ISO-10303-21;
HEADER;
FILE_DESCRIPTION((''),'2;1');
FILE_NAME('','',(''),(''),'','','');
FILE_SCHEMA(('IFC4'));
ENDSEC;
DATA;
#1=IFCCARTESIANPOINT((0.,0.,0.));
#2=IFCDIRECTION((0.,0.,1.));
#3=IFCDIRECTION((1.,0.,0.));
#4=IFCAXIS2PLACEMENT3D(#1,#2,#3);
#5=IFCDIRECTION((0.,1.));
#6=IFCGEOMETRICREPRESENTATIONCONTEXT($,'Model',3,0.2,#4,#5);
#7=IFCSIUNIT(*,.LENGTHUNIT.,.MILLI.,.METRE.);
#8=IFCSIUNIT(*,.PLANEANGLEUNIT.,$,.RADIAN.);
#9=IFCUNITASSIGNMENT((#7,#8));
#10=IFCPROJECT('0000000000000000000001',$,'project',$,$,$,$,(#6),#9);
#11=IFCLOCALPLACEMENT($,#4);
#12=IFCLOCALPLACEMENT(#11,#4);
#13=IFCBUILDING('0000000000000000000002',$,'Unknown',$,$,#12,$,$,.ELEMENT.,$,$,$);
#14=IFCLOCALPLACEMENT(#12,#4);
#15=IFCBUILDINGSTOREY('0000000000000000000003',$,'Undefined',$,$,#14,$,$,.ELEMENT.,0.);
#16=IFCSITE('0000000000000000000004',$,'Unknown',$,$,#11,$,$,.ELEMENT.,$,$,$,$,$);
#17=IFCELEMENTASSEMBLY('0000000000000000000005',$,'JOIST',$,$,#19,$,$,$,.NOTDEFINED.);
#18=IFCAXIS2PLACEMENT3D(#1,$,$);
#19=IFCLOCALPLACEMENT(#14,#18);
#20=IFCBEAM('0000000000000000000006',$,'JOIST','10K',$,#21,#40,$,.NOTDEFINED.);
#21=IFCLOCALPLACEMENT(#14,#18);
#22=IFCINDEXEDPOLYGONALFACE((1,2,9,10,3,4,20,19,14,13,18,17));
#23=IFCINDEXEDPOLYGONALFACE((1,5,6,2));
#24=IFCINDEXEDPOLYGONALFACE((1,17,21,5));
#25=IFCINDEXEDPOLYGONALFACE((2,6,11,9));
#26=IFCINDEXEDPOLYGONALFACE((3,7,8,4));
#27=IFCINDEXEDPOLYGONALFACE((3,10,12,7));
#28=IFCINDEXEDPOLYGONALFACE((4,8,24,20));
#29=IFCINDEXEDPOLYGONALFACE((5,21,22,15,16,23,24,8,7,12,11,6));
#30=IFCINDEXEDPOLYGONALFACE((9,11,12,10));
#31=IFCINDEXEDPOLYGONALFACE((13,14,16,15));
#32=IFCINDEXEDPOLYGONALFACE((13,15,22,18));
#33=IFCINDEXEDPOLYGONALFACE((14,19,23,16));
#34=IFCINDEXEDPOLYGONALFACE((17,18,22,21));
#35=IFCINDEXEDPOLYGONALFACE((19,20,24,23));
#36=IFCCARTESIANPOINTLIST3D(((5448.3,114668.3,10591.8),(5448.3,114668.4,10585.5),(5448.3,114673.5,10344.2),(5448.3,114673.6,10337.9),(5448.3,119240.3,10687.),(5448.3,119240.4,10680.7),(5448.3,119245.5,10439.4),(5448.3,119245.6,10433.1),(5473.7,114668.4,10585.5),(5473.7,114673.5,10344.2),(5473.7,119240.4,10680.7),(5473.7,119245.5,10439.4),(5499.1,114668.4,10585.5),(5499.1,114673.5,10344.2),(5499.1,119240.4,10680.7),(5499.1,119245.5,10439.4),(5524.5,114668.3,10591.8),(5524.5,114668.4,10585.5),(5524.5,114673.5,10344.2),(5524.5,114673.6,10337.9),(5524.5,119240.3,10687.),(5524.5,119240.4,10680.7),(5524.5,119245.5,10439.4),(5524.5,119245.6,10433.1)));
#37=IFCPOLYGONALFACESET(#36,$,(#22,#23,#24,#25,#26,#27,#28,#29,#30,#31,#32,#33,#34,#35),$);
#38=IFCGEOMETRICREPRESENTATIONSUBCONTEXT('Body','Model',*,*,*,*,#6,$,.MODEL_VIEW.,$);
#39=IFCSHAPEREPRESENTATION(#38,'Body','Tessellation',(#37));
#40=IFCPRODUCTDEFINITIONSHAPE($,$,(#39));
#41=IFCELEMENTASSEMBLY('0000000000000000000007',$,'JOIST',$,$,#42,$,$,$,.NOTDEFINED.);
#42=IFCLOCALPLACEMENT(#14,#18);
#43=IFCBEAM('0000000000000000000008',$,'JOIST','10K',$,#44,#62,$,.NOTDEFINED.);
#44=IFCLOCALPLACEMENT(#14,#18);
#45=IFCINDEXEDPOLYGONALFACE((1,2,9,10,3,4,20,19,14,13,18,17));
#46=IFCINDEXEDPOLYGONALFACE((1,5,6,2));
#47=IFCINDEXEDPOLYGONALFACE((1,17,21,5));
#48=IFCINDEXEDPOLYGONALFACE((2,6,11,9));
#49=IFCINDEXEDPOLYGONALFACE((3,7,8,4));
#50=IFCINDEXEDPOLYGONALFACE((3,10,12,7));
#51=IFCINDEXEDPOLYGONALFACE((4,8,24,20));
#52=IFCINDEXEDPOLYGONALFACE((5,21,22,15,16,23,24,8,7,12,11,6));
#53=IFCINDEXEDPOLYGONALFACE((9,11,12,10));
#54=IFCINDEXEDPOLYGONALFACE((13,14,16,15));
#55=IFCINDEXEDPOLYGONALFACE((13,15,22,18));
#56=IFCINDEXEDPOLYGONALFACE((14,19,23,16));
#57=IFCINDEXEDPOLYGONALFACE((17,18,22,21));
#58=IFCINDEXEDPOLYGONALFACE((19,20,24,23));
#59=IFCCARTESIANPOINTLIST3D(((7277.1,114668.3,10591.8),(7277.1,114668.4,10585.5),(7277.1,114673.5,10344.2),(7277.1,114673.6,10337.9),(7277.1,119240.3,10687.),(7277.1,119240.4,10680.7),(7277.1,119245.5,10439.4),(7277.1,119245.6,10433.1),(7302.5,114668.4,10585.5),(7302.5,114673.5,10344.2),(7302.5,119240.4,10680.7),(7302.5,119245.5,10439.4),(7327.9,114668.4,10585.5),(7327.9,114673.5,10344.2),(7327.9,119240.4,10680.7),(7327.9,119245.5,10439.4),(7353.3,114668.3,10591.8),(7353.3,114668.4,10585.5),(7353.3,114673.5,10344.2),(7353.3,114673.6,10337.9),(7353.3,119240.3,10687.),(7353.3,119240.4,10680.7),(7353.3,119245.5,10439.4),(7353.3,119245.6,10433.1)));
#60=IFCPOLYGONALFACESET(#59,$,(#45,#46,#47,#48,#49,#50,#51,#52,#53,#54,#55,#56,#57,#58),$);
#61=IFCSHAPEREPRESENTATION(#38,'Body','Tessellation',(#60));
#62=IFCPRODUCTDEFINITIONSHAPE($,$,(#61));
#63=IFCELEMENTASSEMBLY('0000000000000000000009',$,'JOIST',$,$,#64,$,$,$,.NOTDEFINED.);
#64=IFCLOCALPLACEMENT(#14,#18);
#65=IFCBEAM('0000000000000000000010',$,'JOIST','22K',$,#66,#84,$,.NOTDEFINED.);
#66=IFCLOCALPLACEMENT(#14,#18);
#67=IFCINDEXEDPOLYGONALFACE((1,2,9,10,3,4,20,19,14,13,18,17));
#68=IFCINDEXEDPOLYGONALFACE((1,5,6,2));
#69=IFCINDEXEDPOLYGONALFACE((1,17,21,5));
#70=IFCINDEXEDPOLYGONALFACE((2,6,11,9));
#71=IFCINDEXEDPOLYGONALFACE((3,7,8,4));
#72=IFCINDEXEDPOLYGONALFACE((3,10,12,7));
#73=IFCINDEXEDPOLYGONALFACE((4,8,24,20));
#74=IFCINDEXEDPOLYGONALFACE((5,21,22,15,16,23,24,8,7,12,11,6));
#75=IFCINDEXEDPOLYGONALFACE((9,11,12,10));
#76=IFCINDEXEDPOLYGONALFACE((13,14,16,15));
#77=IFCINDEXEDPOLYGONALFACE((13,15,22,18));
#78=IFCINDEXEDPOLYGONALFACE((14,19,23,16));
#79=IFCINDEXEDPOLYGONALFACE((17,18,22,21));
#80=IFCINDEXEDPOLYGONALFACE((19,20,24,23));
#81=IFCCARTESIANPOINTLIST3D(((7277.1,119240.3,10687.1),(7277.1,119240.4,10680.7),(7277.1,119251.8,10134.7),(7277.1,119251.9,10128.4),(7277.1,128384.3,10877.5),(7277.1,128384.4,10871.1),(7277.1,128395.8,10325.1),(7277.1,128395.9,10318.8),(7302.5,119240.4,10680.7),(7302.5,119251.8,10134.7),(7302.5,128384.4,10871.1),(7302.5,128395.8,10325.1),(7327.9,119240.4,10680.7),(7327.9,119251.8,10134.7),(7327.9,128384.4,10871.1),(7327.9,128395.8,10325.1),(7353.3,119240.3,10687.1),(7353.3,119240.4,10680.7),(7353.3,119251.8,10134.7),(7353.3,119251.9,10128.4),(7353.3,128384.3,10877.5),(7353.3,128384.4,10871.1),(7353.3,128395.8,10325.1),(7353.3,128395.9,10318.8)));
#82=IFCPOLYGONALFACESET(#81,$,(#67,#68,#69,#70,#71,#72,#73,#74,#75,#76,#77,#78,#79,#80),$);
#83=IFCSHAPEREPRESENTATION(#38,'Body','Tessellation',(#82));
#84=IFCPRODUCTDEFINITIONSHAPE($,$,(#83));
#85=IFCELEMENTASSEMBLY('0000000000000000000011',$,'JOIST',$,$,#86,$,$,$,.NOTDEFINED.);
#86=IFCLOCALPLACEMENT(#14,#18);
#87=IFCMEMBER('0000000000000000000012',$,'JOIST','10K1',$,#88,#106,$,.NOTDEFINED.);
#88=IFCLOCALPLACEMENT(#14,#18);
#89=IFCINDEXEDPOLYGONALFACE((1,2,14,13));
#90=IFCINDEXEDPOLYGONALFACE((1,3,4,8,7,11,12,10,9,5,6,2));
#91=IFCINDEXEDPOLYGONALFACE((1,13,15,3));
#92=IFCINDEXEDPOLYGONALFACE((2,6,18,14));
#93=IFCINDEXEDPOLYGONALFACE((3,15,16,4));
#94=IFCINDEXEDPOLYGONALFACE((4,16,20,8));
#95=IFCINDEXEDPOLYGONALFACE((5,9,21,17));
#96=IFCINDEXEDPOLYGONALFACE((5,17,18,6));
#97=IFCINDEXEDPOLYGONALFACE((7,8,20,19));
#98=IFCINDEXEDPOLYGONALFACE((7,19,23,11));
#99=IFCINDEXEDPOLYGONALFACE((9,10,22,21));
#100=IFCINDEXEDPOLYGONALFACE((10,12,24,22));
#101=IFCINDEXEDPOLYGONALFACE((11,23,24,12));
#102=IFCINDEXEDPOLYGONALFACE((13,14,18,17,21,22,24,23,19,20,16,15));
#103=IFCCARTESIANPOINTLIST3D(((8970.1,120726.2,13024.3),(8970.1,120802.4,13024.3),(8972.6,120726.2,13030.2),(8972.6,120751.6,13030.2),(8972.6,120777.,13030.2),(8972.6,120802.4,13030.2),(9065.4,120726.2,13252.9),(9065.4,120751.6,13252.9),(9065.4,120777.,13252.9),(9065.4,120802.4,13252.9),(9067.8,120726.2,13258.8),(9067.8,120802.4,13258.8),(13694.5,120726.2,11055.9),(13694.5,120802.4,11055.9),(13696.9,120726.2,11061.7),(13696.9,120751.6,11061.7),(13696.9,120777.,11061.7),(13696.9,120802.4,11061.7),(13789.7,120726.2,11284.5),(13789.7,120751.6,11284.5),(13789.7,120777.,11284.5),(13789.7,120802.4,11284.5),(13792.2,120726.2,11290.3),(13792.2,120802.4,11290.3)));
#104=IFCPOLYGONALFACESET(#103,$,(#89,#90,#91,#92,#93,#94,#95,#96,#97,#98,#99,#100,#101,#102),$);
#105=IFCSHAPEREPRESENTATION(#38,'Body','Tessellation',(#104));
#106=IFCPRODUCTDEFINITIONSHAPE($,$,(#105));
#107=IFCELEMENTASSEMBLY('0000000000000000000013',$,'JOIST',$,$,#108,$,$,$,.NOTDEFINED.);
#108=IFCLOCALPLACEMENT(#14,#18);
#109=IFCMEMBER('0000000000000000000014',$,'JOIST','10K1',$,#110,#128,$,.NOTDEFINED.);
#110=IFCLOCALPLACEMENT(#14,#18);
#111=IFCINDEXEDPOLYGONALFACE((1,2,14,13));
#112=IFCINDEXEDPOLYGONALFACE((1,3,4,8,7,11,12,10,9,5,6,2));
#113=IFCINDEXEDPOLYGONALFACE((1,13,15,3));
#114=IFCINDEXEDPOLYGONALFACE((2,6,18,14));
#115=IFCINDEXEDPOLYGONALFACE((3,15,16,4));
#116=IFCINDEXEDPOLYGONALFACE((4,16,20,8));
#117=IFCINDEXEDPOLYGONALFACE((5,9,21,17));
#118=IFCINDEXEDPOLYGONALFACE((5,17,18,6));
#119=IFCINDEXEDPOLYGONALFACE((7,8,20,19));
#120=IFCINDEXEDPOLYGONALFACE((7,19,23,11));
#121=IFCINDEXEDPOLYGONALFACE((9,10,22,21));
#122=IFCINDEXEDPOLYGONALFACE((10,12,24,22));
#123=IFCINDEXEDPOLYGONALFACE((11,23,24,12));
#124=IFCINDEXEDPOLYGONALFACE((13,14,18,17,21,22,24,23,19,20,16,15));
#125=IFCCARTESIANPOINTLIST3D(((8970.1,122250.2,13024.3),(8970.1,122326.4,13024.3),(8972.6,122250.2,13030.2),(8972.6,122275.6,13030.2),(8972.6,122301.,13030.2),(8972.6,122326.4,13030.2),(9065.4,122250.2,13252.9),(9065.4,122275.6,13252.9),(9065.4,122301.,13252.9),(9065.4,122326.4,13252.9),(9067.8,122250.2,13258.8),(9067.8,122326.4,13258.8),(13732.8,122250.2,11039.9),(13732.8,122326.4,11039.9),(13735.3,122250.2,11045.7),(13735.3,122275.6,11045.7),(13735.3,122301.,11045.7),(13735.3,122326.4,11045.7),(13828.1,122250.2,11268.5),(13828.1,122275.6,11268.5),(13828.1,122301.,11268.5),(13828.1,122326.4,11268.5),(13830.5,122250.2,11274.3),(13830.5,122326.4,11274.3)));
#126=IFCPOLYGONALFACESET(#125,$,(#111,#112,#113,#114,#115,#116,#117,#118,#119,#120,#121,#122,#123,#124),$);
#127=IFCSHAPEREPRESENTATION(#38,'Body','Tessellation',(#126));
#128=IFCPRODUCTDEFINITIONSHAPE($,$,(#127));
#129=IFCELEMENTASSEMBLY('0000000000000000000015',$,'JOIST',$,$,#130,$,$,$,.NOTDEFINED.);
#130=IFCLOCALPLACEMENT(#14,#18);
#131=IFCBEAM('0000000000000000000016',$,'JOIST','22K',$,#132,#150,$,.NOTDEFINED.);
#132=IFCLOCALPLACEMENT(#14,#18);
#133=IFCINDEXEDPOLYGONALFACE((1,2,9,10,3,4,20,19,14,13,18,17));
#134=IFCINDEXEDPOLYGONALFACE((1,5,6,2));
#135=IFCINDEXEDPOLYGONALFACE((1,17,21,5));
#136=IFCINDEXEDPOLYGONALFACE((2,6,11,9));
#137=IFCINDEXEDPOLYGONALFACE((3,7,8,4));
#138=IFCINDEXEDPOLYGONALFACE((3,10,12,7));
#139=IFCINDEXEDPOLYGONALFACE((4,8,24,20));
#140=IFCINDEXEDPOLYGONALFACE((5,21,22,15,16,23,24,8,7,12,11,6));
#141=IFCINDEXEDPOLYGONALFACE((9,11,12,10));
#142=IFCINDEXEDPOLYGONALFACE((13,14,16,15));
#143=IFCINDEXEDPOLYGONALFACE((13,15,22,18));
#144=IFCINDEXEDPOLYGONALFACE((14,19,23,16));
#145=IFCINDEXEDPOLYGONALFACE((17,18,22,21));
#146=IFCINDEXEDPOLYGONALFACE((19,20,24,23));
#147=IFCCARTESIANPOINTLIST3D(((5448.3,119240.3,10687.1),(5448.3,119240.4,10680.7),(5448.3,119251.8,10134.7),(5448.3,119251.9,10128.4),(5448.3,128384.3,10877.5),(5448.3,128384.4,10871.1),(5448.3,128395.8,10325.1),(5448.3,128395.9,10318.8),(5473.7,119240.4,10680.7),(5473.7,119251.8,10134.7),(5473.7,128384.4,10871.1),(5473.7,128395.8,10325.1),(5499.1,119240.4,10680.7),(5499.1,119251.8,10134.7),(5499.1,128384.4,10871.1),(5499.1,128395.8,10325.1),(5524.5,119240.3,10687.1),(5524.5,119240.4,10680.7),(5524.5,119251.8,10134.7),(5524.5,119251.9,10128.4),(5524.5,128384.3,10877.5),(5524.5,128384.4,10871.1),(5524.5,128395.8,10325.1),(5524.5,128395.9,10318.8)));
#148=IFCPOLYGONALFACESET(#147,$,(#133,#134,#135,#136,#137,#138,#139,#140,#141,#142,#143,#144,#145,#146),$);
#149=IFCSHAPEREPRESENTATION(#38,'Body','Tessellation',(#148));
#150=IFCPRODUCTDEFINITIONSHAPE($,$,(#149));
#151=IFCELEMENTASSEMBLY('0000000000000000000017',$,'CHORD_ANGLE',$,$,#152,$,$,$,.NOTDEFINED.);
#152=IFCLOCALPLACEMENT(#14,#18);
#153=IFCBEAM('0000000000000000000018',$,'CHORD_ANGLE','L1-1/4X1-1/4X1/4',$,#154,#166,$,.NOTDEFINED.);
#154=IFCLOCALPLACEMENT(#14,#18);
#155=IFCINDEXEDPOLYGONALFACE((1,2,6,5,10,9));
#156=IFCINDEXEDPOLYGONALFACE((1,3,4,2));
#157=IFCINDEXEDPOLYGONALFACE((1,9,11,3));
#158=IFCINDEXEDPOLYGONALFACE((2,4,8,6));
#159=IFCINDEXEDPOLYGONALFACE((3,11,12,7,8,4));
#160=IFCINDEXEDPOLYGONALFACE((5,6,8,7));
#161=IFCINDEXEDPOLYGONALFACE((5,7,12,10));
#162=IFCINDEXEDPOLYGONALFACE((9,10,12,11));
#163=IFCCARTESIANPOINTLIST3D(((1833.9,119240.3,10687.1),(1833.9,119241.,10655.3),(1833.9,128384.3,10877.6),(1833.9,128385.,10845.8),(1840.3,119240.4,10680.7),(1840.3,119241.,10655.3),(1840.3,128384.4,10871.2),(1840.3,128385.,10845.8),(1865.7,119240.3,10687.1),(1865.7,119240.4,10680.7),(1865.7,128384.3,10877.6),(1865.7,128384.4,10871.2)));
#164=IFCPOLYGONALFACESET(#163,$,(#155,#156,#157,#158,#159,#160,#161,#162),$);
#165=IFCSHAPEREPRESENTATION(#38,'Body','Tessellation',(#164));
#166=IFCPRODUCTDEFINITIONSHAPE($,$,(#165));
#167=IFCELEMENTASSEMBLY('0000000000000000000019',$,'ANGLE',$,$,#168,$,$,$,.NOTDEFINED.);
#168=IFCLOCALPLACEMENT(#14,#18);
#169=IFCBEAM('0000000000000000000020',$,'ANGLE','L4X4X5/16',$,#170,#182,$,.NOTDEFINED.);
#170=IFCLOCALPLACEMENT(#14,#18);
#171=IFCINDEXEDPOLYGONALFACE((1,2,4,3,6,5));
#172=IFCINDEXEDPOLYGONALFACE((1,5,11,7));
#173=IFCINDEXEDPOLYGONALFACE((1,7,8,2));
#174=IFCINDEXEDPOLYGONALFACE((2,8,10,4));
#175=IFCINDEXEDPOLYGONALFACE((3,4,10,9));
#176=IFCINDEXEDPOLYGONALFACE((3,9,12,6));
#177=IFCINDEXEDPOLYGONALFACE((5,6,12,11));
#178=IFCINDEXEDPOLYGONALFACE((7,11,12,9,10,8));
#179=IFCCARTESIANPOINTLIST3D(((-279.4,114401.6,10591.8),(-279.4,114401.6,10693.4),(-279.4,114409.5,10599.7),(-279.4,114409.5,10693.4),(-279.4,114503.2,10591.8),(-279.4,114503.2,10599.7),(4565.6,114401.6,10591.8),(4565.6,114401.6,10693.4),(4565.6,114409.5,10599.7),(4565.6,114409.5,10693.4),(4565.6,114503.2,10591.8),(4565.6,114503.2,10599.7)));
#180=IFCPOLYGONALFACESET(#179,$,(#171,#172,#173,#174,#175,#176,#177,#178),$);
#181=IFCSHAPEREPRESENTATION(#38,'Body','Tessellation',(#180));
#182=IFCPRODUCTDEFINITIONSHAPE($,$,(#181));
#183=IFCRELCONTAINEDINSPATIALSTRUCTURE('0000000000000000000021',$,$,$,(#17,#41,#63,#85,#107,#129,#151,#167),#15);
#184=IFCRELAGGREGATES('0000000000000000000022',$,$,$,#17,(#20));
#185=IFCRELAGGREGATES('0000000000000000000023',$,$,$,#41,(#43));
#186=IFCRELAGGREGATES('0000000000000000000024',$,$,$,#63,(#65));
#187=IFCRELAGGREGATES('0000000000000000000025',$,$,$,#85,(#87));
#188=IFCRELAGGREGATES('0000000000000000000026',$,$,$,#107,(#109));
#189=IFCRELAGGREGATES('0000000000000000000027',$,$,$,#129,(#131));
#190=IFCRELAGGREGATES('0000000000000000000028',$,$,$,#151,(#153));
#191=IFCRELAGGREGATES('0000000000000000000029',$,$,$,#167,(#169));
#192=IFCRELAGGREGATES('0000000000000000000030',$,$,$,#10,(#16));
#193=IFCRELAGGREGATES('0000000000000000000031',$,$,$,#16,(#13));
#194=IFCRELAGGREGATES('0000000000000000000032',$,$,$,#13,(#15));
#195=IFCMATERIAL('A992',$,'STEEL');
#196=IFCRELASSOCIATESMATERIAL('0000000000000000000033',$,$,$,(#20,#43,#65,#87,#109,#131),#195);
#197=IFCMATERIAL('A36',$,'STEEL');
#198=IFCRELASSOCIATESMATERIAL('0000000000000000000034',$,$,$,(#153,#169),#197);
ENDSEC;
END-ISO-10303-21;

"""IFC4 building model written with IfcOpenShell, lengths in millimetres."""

from ifc_helpers import new_model, si_unit, direction, frame, origin_with_axes, place, context, subcontext, project, spatial, line, indexed_curve, outline, extrude, material, element, aggregate, save


model = new_model("IFC4")

# Units and contexts
model_context = context("Model", 3, precision=0.2, world=origin_with_axes(), true_north=direction((0.0, 1.0)))
body_context = subcontext(model_context, "Body", "Model", "MODEL_VIEW")
ifc_project = project(units=[si_unit("LENGTHUNIT", "METRE", prefix="MILLI"), si_unit("PLANEANGLEUNIT", "RADIAN")], contexts=[model_context])

# Site, building, storey
site_placement = place(None, origin_with_axes())
site = spatial("IfcSite", under=ifc_project, at=site_placement, Name="Unknown", CompositionType="ELEMENT")
building_placement = place(site_placement, origin_with_axes())
building = spatial("IfcBuilding", under=site, at=building_placement, Name="Unknown", CompositionType="ELEMENT")
storey_placement = place(building_placement, origin_with_axes())
storey = spatial("IfcBuildingStorey", under=building, at=storey_placement, Name="Undefined", CompositionType="ELEMENT", Elevation=0.0)

# Shared definitions
ifc_material_1 = material(Name="A992", Category="STEEL")

# Element assemblies, beams
ifc_material_2 = material(Name="A36", Category="STEEL")
assembly_1_placement = place(storey_placement, frame((5486.4, 114670.9, 10464.8), z_axis=(1.0, 0.0, 0.0), x_axis=(0.0, 0.999783, 0.020819)))
assembly_1 = element("IfcElementAssembly", 1, at=assembly_1_placement, inside=storey, Name="JOIST", PredefinedType="NOTDEFINED")
beam_1_placement = place(assembly_1_placement, origin_with_axes())
beam_1 = element("IfcBeam", 2, at=beam_1_placement, material=ifc_material_1, Name="JOIST", Description="10K", PredefinedType="NOTDEFINED", context=body_context, shape_type="SolidModel", body=[
    extrude(outline(indexed_curve([(-38.1, -127.0), (38.1, -127.0), (38.1, -120.7), (12.7, -120.7), (12.7, 120.7), (38.1, 120.7), (38.1, 127.0), (-38.1, 127.0), (-38.1, 120.7), (-12.7, 120.7), (-12.7, -120.7), (-38.1, -120.7)], segments=[line(1, 2, 3, 4, 5, 6, 7, 8, 9, 10, 11, 12, 1)])), frame((0.0, 0.0, 0.0), z_axis=(-1.0, 0.0, 0.0), x_axis=(0.0, 0.0, 1.0)), (0.0, 0.0, -1.0), 4573.0),
])
aggregate(assembly_1, [beam_1])
assembly_2_placement = place(storey_placement, frame((7315.2, 114670.9, 10464.8), z_axis=(1.0, 0.0, 0.0), x_axis=(0.0, 0.999783, 0.020819)))
assembly_2 = element("IfcElementAssembly", 3, at=assembly_2_placement, inside=storey, Name="JOIST", PredefinedType="NOTDEFINED")
beam_2_placement = place(assembly_2_placement, origin_with_axes())
beam_2 = element("IfcBeam", 4, at=beam_2_placement, material=ifc_material_1, Name="JOIST", Description="10K", PredefinedType="NOTDEFINED", context=body_context, shape_type="SolidModel", body=[
    extrude(outline(indexed_curve([(-38.1, -127.0), (38.1, -127.0), (38.1, -120.7), (12.7, -120.7), (12.7, 120.7), (38.1, 120.7), (38.1, 127.0), (-38.1, 127.0), (-38.1, 120.7), (-12.7, 120.7), (-12.7, -120.7), (-38.1, -120.7)], segments=[line(1, 2, 3, 4, 5, 6, 7, 8, 9, 10, 11, 12, 1)])), frame((0.0, 0.0, 0.0), z_axis=(-1.0, 0.0, 0.0), x_axis=(0.0, 0.0, 1.0)), (0.0, 0.0, -1.0), 4573.0),
])
aggregate(assembly_2, [beam_2])
assembly_3_placement = place(storey_placement, frame((7315.2, 119246.1, 10407.7), z_axis=(1.0, 0.0, 0.0), x_axis=(0.0, 0.999783, 0.020819)))
assembly_3 = element("IfcElementAssembly", 5, at=assembly_3_placement, inside=storey, Name="JOIST", PredefinedType="NOTDEFINED")
beam_3_placement = place(assembly_3_placement, origin_with_axes())
beam_3 = element("IfcBeam", 6, at=beam_3_placement, material=ifc_material_1, Name="JOIST", Description="22K", PredefinedType="NOTDEFINED", context=body_context, shape_type="SolidModel", body=[
    extrude(outline(indexed_curve([(-38.1, -279.4), (38.1, -279.4), (38.1, -273.0), (12.7, -273.0), (12.7, 273.0), (38.1, 273.0), (38.1, 279.4), (-38.1, 279.4), (-38.1, 273.0), (-12.7, 273.0), (-12.7, -273.0), (-38.1, -273.0)], segments=[line(1, 2, 3, 4, 5, 6, 7, 8, 9, 10, 11, 12, 1)])), frame((0.0, 0.0, 0.0), z_axis=(-1.0, 0.0, 0.0), x_axis=(0.0, 0.0, 1.0)), (0.0, 0.0, -1.0), 9146.0),
])
aggregate(assembly_3, [beam_3])

# Element assemblies, members
assembly_4_placement = place(storey_placement, frame((9019.0, 120764.3, 13141.6), z_axis=(0.0, -1.0, 0.0), x_axis=(0.923077, 0.000001, -0.384615)))
assembly_4 = element("IfcElementAssembly", 7, at=assembly_4_placement, inside=storey, Name="JOIST", PredefinedType="NOTDEFINED")
member_1_placement = place(assembly_4_placement, origin_with_axes())
member_1 = element("IfcMember", 8, at=member_1_placement, material=ifc_material_1, Name="JOIST", Description="10K1", PredefinedType="NOTDEFINED", context=body_context, shape_type="SolidModel", body=[
    extrude(outline(indexed_curve([(-38.1, -127.0), (38.1, -127.0), (38.1, -120.7), (12.7, -120.7), (12.7, 120.7), (38.1, 120.7), (38.1, 127.0), (-38.1, 127.0), (-38.1, 120.7), (-12.7, 120.7), (-12.7, -120.7), (-38.1, -120.7)], segments=[line(1, 2, 3, 4, 5, 6, 7, 8, 9, 10, 11, 12, 1)])), frame((0.0, 0.0, 0.0), z_axis=(-1.0, 0.0, 0.0), x_axis=(0.0, 0.0, 1.0)), (0.0, 0.0, -1.0), 5118.1),
])
aggregate(assembly_4, [member_1])
assembly_5_placement = place(storey_placement, frame((9019.0, 122288.3, 13141.6), z_axis=(0.0, -1.0, 0.0), x_axis=(0.923077, 0.000001, -0.384615)))
assembly_5 = element("IfcElementAssembly", 9, at=assembly_5_placement, inside=storey, Name="JOIST", PredefinedType="NOTDEFINED")
member_2_placement = place(assembly_5_placement, origin_with_axes())
member_2 = element("IfcMember", 10, at=member_2_placement, material=ifc_material_1, Name="JOIST", Description="10K1", PredefinedType="NOTDEFINED", context=body_context, shape_type="SolidModel", body=[
    extrude(outline(indexed_curve([(-38.1, -127.0), (38.1, -127.0), (38.1, -120.7), (12.7, -120.7), (12.7, 120.7), (38.1, 120.7), (38.1, 127.0), (-38.1, 127.0), (-38.1, 120.7), (-12.7, 120.7), (-12.7, -120.7), (-38.1, -120.7)], segments=[line(1, 2, 3, 4, 5, 6, 7, 8, 9, 10, 11, 12, 1)])), frame((0.0, 0.0, 0.0), z_axis=(-1.0, 0.0, 0.0), x_axis=(0.0, 0.0, 1.0)), (0.0, 0.0, -1.0), 5159.6),
])
aggregate(assembly_5, [member_2])

# Element assemblies, beams
assembly_6_placement = place(storey_placement, frame((5486.4, 119246.1, 10407.7), z_axis=(1.0, 0.0, 0.0), x_axis=(0.0, 0.999783, 0.020819)))
assembly_6 = element("IfcElementAssembly", 11, at=assembly_6_placement, inside=storey, Name="JOIST", PredefinedType="NOTDEFINED")
beam_4_placement = place(assembly_6_placement, origin_with_axes())
beam_4 = element("IfcBeam", 12, at=beam_4_placement, material=ifc_material_1, Name="JOIST", Description="22K", PredefinedType="NOTDEFINED", context=body_context, shape_type="SolidModel", body=[
    extrude(outline(indexed_curve([(-38.1, -279.4), (38.1, -279.4), (38.1, -273.0), (12.7, -273.0), (12.7, 273.0), (38.1, 273.0), (38.1, 279.4), (-38.1, 279.4), (-38.1, 273.0), (-12.7, 273.0), (-12.7, -273.0), (-38.1, -273.0)], segments=[line(1, 2, 3, 4, 5, 6, 7, 8, 9, 10, 11, 12, 1)])), frame((0.0, 0.0, 0.0), z_axis=(-1.0, 0.0, 0.0), x_axis=(0.0, 0.0, 1.0)), (0.0, 0.0, -1.0), 9146.0),
])
aggregate(assembly_6, [beam_4])
assembly_7_placement = place(storey_placement, frame((1849.8, 119240.6, 10671.2), z_axis=(0.0, 0.020829, -0.999783), x_axis=(0.0, 0.999783, 0.020819)))
assembly_7 = element("IfcElementAssembly", 13, at=assembly_7_placement, inside=storey, Name="CHORD_ANGLE", PredefinedType="NOTDEFINED")
beam_5_placement = place(assembly_7_placement, origin_with_axes())
beam_5 = element("IfcBeam", 14, at=beam_5_placement, material=ifc_material_2, Name="CHORD_ANGLE", Description="L1-1/4X1-1/4X1/4", PredefinedType="NOTDEFINED", context=body_context, shape_type="SolidModel", body=[
    extrude(outline(indexed_curve([(-15.9, -15.9), (15.9, -15.9), (15.9, -9.5), (-9.5, -9.5), (-9.5, 15.9), (-15.9, 15.9)], segments=[line(1, 2, 3, 4, 5, 6, 1)])), frame((0.0, 0.0, 0.0), z_axis=(-1.0, 0.0, 0.0), x_axis=(0.0, 0.0, 1.0)), (0.0, 0.0, -1.0), 9146.0),
])
aggregate(assembly_7, [beam_5])
assembly_8_placement = place(storey_placement, frame((4565.6, 114452.4, 10642.6), z_axis=(0.0, 1.0, 0.0), x_axis=(-1.0, 0.0, 0.0)))
assembly_8 = element("IfcElementAssembly", 15, at=assembly_8_placement, inside=storey, Name="ANGLE", PredefinedType="NOTDEFINED")
beam_6_placement = place(assembly_8_placement, origin_with_axes())
beam_6 = element("IfcBeam", 16, at=beam_6_placement, material=ifc_material_2, Name="ANGLE", Description="L4X4X5/16", PredefinedType="NOTDEFINED", context=body_context, shape_type="SolidModel", body=[
    extrude(outline(indexed_curve([(-50.8, -50.8), (50.8, -50.8), (50.8, -42.9), (-42.9, -42.9), (-42.9, 50.8), (-50.8, 50.8)], segments=[line(1, 2, 3, 4, 5, 6, 1)])), frame((0.0, 0.0, 0.0), z_axis=(-1.0, 0.0, 0.0), x_axis=(0.0, 0.0, 1.0)), (0.0, 0.0, -1.0), 4845.1),
])
aggregate(assembly_8, [beam_6])

save(model, "model.ifc")
